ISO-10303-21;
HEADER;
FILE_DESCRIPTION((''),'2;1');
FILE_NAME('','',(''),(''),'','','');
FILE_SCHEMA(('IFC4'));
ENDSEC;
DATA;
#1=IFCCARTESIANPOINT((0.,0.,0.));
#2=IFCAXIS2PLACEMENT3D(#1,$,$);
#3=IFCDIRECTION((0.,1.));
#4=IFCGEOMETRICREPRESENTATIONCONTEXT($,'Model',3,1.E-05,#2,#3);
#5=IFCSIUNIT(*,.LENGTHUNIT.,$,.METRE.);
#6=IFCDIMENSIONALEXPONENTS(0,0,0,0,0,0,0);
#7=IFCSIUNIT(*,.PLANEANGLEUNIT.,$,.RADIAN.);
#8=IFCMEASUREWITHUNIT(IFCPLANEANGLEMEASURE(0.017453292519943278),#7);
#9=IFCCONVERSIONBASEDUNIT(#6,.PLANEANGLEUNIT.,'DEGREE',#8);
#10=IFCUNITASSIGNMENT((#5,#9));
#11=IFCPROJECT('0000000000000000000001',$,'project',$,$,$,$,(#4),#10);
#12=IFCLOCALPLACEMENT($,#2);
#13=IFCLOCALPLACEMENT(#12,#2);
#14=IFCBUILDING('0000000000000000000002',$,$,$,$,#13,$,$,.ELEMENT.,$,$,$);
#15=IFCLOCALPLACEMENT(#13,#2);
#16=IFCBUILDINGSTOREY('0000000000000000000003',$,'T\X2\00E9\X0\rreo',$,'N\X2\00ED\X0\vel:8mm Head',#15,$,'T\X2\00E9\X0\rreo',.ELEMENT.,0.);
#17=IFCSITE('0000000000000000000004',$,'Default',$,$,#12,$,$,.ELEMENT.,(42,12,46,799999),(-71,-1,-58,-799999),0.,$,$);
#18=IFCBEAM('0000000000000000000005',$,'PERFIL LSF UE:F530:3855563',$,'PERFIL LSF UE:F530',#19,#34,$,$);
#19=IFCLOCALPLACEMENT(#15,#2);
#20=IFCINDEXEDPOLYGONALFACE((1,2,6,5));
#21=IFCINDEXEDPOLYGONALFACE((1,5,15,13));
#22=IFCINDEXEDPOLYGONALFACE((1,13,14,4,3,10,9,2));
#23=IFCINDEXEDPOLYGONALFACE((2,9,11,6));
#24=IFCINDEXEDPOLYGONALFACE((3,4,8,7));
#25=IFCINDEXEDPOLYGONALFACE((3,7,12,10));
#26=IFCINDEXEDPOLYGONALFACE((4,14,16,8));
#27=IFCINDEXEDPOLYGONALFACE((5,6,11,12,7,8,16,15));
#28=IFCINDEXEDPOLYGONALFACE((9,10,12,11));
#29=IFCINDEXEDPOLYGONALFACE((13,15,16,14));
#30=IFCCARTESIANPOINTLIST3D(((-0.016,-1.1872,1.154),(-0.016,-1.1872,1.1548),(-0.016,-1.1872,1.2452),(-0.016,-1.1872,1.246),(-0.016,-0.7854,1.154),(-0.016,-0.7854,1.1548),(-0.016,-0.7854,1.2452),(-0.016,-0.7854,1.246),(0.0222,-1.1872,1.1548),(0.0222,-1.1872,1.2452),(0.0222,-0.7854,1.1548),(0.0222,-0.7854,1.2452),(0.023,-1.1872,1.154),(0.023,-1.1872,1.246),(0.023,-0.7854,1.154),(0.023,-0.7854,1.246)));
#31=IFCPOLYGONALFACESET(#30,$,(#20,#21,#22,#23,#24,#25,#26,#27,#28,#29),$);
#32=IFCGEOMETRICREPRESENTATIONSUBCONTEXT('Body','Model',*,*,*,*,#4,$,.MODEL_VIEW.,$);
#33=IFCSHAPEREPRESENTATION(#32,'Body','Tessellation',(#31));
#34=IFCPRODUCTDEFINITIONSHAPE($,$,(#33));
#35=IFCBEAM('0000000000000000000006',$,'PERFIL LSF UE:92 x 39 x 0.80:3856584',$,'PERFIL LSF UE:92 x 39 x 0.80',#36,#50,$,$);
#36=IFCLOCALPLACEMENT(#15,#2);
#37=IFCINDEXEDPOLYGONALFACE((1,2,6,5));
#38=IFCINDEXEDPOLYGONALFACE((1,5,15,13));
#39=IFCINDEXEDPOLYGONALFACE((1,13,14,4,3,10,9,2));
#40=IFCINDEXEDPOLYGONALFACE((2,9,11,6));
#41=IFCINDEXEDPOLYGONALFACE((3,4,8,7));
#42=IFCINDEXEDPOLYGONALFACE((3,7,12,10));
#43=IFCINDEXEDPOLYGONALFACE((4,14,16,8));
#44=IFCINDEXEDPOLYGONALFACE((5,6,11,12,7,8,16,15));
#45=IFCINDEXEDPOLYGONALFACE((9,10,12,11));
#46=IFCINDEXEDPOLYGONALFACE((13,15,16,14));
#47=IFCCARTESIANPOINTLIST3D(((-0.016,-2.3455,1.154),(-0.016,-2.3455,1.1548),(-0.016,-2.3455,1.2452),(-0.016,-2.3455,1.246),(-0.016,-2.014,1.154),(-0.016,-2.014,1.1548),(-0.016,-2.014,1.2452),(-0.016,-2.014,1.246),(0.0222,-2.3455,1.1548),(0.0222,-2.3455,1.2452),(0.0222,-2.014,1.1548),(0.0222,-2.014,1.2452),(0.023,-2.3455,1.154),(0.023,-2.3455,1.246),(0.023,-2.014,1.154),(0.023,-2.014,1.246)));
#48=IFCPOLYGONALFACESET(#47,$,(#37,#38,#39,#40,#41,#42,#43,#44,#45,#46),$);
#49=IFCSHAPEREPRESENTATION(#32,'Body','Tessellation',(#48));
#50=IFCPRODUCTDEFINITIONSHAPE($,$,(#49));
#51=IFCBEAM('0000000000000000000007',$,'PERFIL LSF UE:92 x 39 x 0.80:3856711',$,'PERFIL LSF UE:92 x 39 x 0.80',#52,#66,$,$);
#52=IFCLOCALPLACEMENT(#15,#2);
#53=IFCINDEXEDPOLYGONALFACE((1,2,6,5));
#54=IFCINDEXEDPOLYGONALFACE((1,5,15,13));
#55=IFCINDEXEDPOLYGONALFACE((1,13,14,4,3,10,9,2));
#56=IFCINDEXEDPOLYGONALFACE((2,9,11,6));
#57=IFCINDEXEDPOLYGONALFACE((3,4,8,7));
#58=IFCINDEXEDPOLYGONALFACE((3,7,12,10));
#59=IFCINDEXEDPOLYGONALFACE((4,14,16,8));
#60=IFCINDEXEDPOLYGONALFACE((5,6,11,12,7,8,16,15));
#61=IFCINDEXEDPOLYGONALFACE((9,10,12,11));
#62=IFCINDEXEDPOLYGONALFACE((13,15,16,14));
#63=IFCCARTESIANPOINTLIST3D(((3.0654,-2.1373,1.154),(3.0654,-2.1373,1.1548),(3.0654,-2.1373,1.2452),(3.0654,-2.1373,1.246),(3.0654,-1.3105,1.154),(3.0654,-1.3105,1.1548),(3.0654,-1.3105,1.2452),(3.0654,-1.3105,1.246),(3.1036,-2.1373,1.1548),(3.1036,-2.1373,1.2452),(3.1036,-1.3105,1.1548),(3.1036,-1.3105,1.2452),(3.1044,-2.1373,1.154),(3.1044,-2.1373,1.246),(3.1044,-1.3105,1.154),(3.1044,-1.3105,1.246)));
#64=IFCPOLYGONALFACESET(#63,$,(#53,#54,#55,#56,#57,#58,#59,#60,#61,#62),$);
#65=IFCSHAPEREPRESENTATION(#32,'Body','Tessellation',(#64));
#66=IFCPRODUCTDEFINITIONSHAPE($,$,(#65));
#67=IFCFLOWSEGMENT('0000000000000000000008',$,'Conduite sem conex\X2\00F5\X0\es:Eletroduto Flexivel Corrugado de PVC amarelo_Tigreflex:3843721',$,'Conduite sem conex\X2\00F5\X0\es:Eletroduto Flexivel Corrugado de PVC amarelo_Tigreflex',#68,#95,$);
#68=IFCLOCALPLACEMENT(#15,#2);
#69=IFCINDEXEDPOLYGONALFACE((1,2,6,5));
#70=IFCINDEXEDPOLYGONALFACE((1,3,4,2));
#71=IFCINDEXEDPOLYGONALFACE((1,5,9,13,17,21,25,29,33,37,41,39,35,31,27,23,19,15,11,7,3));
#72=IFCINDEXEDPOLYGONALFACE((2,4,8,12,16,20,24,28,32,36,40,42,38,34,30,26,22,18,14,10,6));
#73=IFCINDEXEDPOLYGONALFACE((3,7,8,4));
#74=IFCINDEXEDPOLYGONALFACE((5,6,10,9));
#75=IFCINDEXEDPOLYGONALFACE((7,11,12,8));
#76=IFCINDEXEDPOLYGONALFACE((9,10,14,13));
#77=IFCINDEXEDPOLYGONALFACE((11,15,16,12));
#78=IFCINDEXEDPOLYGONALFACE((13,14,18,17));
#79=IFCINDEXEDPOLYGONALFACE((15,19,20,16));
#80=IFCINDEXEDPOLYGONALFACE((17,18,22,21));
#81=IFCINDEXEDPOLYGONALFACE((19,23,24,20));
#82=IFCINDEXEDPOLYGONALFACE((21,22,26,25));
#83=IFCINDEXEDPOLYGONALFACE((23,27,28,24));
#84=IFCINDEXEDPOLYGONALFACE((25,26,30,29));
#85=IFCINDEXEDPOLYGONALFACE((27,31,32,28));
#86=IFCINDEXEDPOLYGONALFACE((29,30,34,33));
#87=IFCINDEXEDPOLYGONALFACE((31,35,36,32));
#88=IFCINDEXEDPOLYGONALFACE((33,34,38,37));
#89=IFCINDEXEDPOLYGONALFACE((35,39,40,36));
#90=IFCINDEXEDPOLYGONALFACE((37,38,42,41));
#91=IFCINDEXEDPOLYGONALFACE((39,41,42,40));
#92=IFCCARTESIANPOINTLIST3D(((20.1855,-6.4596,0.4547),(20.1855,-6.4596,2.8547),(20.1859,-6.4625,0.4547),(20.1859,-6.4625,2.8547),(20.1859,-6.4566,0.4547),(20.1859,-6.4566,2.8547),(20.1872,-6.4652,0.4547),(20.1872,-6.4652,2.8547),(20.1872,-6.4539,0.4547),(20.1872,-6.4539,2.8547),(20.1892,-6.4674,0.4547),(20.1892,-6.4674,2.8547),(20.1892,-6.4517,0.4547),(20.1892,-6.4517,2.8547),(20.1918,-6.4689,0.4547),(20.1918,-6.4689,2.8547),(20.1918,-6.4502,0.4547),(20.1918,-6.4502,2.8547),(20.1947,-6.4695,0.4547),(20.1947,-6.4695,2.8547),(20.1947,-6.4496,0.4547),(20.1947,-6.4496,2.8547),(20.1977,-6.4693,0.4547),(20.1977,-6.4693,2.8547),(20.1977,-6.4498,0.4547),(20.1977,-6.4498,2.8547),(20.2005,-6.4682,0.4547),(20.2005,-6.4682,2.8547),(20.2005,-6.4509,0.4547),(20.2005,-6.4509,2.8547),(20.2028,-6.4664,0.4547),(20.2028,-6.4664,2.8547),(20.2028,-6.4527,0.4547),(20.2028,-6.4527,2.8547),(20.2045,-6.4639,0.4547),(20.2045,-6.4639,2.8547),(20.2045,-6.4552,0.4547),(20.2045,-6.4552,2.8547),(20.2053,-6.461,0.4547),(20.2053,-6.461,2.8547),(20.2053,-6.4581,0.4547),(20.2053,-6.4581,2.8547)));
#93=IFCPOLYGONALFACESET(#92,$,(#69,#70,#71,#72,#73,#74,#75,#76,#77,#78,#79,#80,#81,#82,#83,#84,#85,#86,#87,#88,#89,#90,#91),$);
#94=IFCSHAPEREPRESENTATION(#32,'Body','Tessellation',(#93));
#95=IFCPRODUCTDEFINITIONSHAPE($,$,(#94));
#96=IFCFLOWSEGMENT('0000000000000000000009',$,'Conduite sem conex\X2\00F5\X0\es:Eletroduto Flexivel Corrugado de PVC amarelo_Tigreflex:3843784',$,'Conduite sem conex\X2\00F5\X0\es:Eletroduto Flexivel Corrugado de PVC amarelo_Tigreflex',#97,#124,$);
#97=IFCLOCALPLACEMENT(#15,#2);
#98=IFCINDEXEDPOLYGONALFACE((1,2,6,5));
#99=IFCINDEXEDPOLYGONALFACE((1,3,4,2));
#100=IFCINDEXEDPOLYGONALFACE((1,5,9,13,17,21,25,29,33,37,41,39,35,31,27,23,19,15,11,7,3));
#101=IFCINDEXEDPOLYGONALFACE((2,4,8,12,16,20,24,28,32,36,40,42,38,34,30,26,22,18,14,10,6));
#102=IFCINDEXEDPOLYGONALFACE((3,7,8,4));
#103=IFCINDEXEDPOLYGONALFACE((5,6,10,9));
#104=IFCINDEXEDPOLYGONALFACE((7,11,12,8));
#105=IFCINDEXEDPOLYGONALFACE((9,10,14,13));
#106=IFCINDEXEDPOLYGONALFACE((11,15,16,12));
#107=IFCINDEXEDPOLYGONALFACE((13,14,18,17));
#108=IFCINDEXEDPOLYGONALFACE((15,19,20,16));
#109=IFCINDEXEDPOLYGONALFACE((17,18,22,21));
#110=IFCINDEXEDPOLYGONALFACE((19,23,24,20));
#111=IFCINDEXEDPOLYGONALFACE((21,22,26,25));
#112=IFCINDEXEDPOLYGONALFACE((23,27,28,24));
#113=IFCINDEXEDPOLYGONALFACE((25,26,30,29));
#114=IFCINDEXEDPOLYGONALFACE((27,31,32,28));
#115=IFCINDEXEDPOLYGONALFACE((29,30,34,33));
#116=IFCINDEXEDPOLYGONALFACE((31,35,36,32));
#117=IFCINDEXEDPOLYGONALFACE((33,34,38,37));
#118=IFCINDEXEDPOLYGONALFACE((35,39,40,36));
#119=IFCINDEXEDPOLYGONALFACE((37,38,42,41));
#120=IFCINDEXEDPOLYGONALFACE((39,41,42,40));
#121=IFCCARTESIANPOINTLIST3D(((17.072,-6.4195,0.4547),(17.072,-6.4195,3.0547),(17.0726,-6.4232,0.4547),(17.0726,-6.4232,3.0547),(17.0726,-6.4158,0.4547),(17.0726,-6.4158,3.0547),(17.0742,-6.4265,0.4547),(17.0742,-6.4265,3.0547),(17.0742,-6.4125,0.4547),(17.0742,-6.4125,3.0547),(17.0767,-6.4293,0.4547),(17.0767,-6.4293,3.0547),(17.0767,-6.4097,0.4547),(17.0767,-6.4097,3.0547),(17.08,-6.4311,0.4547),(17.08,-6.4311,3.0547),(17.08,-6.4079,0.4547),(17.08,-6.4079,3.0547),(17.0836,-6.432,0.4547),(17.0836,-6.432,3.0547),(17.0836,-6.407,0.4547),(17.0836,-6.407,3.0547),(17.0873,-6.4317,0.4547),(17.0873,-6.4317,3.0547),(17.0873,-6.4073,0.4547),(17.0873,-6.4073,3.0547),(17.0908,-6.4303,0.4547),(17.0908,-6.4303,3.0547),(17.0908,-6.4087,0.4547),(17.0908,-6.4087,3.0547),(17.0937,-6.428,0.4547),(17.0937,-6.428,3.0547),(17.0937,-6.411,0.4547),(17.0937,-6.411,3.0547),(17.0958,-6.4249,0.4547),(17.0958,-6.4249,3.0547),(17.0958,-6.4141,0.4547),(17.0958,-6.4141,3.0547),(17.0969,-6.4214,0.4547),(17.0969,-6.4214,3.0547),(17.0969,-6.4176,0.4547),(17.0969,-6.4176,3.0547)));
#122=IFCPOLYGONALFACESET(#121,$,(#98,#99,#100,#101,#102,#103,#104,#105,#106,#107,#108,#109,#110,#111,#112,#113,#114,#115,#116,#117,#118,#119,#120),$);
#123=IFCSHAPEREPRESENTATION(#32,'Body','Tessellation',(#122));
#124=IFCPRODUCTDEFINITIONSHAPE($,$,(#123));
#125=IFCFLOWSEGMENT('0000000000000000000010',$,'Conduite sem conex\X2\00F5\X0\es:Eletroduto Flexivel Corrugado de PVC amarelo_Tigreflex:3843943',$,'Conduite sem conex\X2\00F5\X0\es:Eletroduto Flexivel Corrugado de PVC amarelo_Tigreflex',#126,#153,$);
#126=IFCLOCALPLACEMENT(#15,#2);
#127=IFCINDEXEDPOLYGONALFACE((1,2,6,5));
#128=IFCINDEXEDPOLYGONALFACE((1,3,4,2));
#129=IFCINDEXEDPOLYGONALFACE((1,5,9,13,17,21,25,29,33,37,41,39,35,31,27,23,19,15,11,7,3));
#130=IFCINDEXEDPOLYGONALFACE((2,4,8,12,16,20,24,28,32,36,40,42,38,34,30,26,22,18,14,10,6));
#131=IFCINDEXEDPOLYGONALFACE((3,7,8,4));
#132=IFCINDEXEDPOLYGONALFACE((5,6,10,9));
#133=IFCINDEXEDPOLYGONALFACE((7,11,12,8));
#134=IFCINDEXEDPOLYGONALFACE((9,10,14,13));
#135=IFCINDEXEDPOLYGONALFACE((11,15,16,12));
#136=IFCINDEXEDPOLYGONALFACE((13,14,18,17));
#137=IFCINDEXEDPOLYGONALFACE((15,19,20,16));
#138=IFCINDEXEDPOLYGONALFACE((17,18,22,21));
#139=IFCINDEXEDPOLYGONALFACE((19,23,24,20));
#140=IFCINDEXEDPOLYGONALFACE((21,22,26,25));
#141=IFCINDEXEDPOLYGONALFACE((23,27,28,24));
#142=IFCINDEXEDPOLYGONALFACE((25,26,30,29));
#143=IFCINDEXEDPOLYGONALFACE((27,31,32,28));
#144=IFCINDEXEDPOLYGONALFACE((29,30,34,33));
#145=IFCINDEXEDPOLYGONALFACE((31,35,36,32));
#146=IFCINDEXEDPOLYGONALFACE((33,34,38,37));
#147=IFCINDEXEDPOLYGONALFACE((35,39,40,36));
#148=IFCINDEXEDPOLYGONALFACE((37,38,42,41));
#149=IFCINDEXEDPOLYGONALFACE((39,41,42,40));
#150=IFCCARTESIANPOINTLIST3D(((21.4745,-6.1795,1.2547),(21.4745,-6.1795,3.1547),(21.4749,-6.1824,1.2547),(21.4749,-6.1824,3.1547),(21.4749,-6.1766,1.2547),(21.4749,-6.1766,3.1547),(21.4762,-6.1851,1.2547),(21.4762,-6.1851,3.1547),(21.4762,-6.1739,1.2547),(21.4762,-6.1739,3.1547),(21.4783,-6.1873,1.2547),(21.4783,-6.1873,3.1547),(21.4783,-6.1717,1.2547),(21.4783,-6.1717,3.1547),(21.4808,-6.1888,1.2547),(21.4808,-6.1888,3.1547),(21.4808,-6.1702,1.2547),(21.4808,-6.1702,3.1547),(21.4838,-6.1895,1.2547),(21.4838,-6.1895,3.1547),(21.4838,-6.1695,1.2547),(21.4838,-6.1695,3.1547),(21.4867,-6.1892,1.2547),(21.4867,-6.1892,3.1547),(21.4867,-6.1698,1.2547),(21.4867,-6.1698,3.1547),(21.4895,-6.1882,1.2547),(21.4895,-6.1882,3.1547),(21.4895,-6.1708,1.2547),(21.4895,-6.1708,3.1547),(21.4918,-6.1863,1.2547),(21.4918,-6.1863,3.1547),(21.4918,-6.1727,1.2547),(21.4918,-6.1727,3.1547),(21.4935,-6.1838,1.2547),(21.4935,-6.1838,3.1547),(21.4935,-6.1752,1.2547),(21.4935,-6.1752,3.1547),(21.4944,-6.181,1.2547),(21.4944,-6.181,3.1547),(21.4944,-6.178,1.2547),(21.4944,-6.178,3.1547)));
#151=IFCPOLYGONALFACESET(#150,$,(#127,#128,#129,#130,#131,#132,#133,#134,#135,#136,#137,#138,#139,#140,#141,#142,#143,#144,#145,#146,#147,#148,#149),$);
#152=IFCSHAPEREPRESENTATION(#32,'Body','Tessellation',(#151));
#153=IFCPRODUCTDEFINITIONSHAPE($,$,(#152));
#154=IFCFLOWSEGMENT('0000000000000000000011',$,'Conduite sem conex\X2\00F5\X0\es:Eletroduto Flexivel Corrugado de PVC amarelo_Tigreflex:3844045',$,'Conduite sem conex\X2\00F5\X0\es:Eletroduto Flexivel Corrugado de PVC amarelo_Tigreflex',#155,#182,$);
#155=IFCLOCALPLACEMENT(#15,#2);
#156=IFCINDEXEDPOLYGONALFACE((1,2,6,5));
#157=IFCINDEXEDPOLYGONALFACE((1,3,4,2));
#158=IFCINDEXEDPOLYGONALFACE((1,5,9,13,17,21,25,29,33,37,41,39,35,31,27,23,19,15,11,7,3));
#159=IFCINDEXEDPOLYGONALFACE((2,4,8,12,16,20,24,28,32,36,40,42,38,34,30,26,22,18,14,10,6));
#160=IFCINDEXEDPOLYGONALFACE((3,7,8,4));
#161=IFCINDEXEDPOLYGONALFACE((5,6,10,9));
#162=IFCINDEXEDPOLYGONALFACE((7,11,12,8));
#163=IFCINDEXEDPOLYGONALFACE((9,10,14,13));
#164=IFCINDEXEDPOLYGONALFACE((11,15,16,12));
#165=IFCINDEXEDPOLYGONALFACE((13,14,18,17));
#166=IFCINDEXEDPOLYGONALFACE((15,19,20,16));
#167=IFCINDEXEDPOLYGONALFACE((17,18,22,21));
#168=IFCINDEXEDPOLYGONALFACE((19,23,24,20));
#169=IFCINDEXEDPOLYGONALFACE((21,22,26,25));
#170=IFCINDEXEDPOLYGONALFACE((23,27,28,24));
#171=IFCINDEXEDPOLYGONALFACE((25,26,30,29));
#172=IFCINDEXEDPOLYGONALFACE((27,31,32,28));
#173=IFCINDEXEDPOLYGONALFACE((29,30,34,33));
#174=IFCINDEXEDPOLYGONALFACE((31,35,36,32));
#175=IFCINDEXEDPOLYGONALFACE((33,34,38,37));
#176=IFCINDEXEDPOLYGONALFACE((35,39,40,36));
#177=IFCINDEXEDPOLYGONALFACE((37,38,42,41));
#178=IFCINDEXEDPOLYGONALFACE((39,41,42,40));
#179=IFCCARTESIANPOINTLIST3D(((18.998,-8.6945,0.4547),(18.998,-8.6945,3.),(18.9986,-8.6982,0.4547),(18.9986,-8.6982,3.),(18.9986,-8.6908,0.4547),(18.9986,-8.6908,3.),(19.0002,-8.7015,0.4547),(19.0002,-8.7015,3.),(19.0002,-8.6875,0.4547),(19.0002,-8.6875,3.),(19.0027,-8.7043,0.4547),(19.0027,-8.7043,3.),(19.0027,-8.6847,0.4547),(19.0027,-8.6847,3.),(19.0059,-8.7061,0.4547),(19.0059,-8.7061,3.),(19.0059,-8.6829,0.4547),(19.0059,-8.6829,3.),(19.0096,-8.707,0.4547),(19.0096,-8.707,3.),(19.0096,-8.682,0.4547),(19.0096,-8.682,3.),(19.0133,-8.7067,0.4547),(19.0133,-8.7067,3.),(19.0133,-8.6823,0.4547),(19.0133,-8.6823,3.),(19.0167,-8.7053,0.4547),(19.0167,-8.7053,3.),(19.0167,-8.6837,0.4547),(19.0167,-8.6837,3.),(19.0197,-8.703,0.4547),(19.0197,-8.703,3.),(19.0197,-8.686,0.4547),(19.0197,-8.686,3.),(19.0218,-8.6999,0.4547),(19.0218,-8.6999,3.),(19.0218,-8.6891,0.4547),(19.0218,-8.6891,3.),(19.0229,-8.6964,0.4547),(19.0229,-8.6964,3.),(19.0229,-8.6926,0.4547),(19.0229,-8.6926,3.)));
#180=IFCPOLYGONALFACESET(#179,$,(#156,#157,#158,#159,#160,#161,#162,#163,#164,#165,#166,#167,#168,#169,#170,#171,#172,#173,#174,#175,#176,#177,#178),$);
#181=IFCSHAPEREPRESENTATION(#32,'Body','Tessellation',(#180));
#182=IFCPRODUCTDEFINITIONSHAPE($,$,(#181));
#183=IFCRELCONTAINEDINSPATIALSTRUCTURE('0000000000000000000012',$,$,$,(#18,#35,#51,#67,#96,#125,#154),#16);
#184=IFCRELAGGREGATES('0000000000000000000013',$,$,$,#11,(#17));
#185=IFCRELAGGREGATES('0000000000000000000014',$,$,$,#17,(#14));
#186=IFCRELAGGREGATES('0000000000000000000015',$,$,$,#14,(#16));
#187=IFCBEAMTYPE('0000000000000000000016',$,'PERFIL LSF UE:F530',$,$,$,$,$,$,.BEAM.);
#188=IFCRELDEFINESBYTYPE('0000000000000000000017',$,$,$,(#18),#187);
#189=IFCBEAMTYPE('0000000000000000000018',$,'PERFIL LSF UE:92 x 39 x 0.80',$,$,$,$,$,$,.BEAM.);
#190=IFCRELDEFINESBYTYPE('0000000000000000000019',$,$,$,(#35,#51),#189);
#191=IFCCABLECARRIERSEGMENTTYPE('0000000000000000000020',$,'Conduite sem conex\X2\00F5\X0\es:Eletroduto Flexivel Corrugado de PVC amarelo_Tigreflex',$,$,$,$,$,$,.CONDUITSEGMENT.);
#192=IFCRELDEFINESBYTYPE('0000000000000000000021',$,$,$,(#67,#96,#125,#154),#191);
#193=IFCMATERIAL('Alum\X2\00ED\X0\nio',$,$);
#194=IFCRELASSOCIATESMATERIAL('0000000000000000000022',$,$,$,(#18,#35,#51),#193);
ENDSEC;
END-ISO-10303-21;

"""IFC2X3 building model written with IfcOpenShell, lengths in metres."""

from ifc_helpers import new_model, entity, si_unit, converted_unit, direction, frame, frame_2d, origin, origin_2d_with_axis, place, context, subcontext, project, spatial, polyline, circle, outline, extrude, material, type_object, element, save


model = new_model("IFC2X3")

# Units and contexts
model_context = context("Model", 3, precision=1e-05, world=origin(), true_north=direction((0.0, 1.0)))
body_context = subcontext(model_context, "Body", "Model", "MODEL_VIEW")
ifc_project = project(units=[si_unit("LENGTHUNIT", "METRE"), converted_unit("PLANEANGLEUNIT", "DEGREE", entity("IfcPlaneAngleMeasure", 0.017453292519943278), si_unit("PLANEANGLEUNIT", "RADIAN"), dimensions=[0, 0, 0, 0, 0, 0, 0])], contexts=[model_context])

# Site, building, storey
site_placement = place(None, origin())
site = spatial("IfcSite", under=ifc_project, at=site_placement, Name="Default", CompositionType="ELEMENT", RefLatitude=(42, 12, 46, 799999), RefLongitude=(-71, -1, -58, -799999), RefElevation=0.0)
building_placement = place(site_placement, origin())
building = spatial("IfcBuilding", under=site, at=building_placement, CompositionType="ELEMENT")
storey_placement = place(building_placement, origin())
storey = spatial("IfcBuildingStorey", under=building, at=storey_placement, Name="Térreo", ObjectType="Nível:8mm Head", LongName="Térreo", CompositionType="ELEMENT", Elevation=0.0)

# Beams
ifc_material_1 = material(Name="Alumínio")
beam_type_1 = type_object("IfcBeamType", Name="PERFIL LSF UE:F530", PredefinedType="BEAM")
beam_1_placement = place(storey_placement, frame((-0.016, -0.7854, 1.2), z_axis=(0.0, 0.0, 1.0), x_axis=(0.0, -1.0, 0.0)))
element("IfcBeam", 1, at=beam_1_placement, inside=storey, type_object=beam_type_1, material=ifc_material_1, Name="PERFIL LSF UE:F530:3855563", ObjectType="PERFIL LSF UE:F530", context=body_context, shape_type="SweptSolid", body=[
    extrude(outline(polyline([(-0.046, -0.0193), (-0.0452, -0.0193), (-0.0452, 0.0189), (0.0452, 0.0189), (0.0452, -0.0193), (0.046, -0.0193), (0.046, 0.0197), (-0.046, 0.0197), (-0.046, -0.0193)])), frame((0.0, 0.0193, 0.0), z_axis=(1.0, 0.0, 0.0), x_axis=(0.0, 0.0, -1.0)), (0.0, 0.0, 1.0), 0.4018),
])
beam_type_2 = type_object("IfcBeamType", Name="PERFIL LSF UE:92 x 39 x 0.80", PredefinedType="BEAM")
beam_2_placement = place(storey_placement, frame((-0.016, -2.014, 1.2), z_axis=(0.0, 0.0, 1.0), x_axis=(0.0, -1.0, 0.0)))
element("IfcBeam", 2, at=beam_2_placement, inside=storey, type_object=beam_type_2, material=ifc_material_1, Name="PERFIL LSF UE:92 x 39 x 0.80:3856584", ObjectType="PERFIL LSF UE:92 x 39 x 0.80", context=body_context, shape_type="SweptSolid", body=[
    extrude(outline(polyline([(-0.046, -0.0193), (-0.0452, -0.0193), (-0.0452, 0.0189), (0.0452, 0.0189), (0.0452, -0.0193), (0.046, -0.0193), (0.046, 0.0197), (-0.046, 0.0197), (-0.046, -0.0193)])), frame((0.0, 0.0193, 0.0), z_axis=(1.0, 0.0, 0.0), x_axis=(0.0, 0.0, -1.0)), (0.0, 0.0, 1.0), 0.3315),
])
beam_3_placement = place(storey_placement, frame((3.0654, -1.3105, 1.2), z_axis=(0.0, 0.0, 1.0), x_axis=(0.0, -1.0, 0.0)))
element("IfcBeam", 3, at=beam_3_placement, inside=storey, type_object=beam_type_2, material=ifc_material_1, Name="PERFIL LSF UE:92 x 39 x 0.80:3856711", ObjectType="PERFIL LSF UE:92 x 39 x 0.80", context=body_context, shape_type="SweptSolid", body=[
    extrude(outline(polyline([(-0.046, -0.0193), (-0.0452, -0.0193), (-0.0452, 0.0189), (0.0452, 0.0189), (0.0452, -0.0193), (0.046, -0.0193), (0.046, 0.0197), (-0.046, 0.0197), (-0.046, -0.0193)])), frame((0.0, 0.0193, 0.0), z_axis=(1.0, 0.0, 0.0), x_axis=(0.0, 0.0, -1.0)), (0.0, 0.0, 1.0), 0.8268),
])

# Flow segments
cable_carrier_segment_type = type_object("IfcCableCarrierSegmentType", Name="Conduite sem conexões:Eletroduto Flexivel Corrugado de PVC amarelo_Tigreflex", PredefinedType="CONDUITSEGMENT")
flow_segment_1_placement = place(storey_placement, origin())
element("IfcFlowSegment", 4, at=flow_segment_1_placement, inside=storey, type_object=cable_carrier_segment_type, Name="Conduite sem conexões:Eletroduto Flexivel Corrugado de PVC amarelo_Tigreflex:3843721", ObjectType="Conduite sem conexões:Eletroduto Flexivel Corrugado de PVC amarelo_Tigreflex", context=body_context, shape_type="SweptSolid", body=[
    extrude(circle(Radius=0.01, at=origin_2d_with_axis()), frame((20.1955, -6.4596, 0.4547), z_axis=(0.0, 0.0, 1.0), x_axis=(-1.0, 0.0, 0.0)), (0.0, 0.0, 1.0), 2.4),
])
flow_segment_2_placement = place(storey_placement, origin())
element("IfcFlowSegment", 5, at=flow_segment_2_placement, inside=storey, type_object=cable_carrier_segment_type, Name="Conduite sem conexões:Eletroduto Flexivel Corrugado de PVC amarelo_Tigreflex:3843784", ObjectType="Conduite sem conexões:Eletroduto Flexivel Corrugado de PVC amarelo_Tigreflex", context=body_context, shape_type="SweptSolid", body=[
    extrude(circle(Radius=0.0125, at=origin_2d_with_axis()), frame((17.0845, -6.4195, 0.4547), z_axis=(0.0, 0.0, 1.0), x_axis=(-1.0, 0.0, 0.0)), (0.0, 0.0, 1.0), 2.6),
])
flow_segment_3_placement = place(storey_placement, origin())
element("IfcFlowSegment", 6, at=flow_segment_3_placement, inside=storey, type_object=cable_carrier_segment_type, Name="Conduite sem conexões:Eletroduto Flexivel Corrugado de PVC amarelo_Tigreflex:3843943", ObjectType="Conduite sem conexões:Eletroduto Flexivel Corrugado de PVC amarelo_Tigreflex", context=body_context, shape_type="SweptSolid", body=[
    extrude(circle(Radius=0.01, at=origin_2d_with_axis()), frame((21.4845, -6.1795, 1.2547), z_axis=(0.0, 0.0, 1.0), x_axis=(-1.0, 0.0, 0.0)), (0.0, 0.0, 1.0), 1.9),
])
flow_segment_4_placement = place(storey_placement, origin())
element("IfcFlowSegment", 7, at=flow_segment_4_placement, inside=storey, type_object=cable_carrier_segment_type, Name="Conduite sem conexões:Eletroduto Flexivel Corrugado de PVC amarelo_Tigreflex:3844045", ObjectType="Conduite sem conexões:Eletroduto Flexivel Corrugado de PVC amarelo_Tigreflex", context=body_context, shape_type="SweptSolid", body=[
    extrude(circle(Radius=0.0125, at=frame_2d((0.0, 0.0), x_axis=(1.0, 0.0))), frame((19.0105, -8.6945, 0.4547), z_axis=(0.0, 0.0, 1.0), x_axis=(-1.0, 0.0, 0.0)), (0.0, 0.0, 1.0), 2.5453),
])

save(model, "model.ifc")
